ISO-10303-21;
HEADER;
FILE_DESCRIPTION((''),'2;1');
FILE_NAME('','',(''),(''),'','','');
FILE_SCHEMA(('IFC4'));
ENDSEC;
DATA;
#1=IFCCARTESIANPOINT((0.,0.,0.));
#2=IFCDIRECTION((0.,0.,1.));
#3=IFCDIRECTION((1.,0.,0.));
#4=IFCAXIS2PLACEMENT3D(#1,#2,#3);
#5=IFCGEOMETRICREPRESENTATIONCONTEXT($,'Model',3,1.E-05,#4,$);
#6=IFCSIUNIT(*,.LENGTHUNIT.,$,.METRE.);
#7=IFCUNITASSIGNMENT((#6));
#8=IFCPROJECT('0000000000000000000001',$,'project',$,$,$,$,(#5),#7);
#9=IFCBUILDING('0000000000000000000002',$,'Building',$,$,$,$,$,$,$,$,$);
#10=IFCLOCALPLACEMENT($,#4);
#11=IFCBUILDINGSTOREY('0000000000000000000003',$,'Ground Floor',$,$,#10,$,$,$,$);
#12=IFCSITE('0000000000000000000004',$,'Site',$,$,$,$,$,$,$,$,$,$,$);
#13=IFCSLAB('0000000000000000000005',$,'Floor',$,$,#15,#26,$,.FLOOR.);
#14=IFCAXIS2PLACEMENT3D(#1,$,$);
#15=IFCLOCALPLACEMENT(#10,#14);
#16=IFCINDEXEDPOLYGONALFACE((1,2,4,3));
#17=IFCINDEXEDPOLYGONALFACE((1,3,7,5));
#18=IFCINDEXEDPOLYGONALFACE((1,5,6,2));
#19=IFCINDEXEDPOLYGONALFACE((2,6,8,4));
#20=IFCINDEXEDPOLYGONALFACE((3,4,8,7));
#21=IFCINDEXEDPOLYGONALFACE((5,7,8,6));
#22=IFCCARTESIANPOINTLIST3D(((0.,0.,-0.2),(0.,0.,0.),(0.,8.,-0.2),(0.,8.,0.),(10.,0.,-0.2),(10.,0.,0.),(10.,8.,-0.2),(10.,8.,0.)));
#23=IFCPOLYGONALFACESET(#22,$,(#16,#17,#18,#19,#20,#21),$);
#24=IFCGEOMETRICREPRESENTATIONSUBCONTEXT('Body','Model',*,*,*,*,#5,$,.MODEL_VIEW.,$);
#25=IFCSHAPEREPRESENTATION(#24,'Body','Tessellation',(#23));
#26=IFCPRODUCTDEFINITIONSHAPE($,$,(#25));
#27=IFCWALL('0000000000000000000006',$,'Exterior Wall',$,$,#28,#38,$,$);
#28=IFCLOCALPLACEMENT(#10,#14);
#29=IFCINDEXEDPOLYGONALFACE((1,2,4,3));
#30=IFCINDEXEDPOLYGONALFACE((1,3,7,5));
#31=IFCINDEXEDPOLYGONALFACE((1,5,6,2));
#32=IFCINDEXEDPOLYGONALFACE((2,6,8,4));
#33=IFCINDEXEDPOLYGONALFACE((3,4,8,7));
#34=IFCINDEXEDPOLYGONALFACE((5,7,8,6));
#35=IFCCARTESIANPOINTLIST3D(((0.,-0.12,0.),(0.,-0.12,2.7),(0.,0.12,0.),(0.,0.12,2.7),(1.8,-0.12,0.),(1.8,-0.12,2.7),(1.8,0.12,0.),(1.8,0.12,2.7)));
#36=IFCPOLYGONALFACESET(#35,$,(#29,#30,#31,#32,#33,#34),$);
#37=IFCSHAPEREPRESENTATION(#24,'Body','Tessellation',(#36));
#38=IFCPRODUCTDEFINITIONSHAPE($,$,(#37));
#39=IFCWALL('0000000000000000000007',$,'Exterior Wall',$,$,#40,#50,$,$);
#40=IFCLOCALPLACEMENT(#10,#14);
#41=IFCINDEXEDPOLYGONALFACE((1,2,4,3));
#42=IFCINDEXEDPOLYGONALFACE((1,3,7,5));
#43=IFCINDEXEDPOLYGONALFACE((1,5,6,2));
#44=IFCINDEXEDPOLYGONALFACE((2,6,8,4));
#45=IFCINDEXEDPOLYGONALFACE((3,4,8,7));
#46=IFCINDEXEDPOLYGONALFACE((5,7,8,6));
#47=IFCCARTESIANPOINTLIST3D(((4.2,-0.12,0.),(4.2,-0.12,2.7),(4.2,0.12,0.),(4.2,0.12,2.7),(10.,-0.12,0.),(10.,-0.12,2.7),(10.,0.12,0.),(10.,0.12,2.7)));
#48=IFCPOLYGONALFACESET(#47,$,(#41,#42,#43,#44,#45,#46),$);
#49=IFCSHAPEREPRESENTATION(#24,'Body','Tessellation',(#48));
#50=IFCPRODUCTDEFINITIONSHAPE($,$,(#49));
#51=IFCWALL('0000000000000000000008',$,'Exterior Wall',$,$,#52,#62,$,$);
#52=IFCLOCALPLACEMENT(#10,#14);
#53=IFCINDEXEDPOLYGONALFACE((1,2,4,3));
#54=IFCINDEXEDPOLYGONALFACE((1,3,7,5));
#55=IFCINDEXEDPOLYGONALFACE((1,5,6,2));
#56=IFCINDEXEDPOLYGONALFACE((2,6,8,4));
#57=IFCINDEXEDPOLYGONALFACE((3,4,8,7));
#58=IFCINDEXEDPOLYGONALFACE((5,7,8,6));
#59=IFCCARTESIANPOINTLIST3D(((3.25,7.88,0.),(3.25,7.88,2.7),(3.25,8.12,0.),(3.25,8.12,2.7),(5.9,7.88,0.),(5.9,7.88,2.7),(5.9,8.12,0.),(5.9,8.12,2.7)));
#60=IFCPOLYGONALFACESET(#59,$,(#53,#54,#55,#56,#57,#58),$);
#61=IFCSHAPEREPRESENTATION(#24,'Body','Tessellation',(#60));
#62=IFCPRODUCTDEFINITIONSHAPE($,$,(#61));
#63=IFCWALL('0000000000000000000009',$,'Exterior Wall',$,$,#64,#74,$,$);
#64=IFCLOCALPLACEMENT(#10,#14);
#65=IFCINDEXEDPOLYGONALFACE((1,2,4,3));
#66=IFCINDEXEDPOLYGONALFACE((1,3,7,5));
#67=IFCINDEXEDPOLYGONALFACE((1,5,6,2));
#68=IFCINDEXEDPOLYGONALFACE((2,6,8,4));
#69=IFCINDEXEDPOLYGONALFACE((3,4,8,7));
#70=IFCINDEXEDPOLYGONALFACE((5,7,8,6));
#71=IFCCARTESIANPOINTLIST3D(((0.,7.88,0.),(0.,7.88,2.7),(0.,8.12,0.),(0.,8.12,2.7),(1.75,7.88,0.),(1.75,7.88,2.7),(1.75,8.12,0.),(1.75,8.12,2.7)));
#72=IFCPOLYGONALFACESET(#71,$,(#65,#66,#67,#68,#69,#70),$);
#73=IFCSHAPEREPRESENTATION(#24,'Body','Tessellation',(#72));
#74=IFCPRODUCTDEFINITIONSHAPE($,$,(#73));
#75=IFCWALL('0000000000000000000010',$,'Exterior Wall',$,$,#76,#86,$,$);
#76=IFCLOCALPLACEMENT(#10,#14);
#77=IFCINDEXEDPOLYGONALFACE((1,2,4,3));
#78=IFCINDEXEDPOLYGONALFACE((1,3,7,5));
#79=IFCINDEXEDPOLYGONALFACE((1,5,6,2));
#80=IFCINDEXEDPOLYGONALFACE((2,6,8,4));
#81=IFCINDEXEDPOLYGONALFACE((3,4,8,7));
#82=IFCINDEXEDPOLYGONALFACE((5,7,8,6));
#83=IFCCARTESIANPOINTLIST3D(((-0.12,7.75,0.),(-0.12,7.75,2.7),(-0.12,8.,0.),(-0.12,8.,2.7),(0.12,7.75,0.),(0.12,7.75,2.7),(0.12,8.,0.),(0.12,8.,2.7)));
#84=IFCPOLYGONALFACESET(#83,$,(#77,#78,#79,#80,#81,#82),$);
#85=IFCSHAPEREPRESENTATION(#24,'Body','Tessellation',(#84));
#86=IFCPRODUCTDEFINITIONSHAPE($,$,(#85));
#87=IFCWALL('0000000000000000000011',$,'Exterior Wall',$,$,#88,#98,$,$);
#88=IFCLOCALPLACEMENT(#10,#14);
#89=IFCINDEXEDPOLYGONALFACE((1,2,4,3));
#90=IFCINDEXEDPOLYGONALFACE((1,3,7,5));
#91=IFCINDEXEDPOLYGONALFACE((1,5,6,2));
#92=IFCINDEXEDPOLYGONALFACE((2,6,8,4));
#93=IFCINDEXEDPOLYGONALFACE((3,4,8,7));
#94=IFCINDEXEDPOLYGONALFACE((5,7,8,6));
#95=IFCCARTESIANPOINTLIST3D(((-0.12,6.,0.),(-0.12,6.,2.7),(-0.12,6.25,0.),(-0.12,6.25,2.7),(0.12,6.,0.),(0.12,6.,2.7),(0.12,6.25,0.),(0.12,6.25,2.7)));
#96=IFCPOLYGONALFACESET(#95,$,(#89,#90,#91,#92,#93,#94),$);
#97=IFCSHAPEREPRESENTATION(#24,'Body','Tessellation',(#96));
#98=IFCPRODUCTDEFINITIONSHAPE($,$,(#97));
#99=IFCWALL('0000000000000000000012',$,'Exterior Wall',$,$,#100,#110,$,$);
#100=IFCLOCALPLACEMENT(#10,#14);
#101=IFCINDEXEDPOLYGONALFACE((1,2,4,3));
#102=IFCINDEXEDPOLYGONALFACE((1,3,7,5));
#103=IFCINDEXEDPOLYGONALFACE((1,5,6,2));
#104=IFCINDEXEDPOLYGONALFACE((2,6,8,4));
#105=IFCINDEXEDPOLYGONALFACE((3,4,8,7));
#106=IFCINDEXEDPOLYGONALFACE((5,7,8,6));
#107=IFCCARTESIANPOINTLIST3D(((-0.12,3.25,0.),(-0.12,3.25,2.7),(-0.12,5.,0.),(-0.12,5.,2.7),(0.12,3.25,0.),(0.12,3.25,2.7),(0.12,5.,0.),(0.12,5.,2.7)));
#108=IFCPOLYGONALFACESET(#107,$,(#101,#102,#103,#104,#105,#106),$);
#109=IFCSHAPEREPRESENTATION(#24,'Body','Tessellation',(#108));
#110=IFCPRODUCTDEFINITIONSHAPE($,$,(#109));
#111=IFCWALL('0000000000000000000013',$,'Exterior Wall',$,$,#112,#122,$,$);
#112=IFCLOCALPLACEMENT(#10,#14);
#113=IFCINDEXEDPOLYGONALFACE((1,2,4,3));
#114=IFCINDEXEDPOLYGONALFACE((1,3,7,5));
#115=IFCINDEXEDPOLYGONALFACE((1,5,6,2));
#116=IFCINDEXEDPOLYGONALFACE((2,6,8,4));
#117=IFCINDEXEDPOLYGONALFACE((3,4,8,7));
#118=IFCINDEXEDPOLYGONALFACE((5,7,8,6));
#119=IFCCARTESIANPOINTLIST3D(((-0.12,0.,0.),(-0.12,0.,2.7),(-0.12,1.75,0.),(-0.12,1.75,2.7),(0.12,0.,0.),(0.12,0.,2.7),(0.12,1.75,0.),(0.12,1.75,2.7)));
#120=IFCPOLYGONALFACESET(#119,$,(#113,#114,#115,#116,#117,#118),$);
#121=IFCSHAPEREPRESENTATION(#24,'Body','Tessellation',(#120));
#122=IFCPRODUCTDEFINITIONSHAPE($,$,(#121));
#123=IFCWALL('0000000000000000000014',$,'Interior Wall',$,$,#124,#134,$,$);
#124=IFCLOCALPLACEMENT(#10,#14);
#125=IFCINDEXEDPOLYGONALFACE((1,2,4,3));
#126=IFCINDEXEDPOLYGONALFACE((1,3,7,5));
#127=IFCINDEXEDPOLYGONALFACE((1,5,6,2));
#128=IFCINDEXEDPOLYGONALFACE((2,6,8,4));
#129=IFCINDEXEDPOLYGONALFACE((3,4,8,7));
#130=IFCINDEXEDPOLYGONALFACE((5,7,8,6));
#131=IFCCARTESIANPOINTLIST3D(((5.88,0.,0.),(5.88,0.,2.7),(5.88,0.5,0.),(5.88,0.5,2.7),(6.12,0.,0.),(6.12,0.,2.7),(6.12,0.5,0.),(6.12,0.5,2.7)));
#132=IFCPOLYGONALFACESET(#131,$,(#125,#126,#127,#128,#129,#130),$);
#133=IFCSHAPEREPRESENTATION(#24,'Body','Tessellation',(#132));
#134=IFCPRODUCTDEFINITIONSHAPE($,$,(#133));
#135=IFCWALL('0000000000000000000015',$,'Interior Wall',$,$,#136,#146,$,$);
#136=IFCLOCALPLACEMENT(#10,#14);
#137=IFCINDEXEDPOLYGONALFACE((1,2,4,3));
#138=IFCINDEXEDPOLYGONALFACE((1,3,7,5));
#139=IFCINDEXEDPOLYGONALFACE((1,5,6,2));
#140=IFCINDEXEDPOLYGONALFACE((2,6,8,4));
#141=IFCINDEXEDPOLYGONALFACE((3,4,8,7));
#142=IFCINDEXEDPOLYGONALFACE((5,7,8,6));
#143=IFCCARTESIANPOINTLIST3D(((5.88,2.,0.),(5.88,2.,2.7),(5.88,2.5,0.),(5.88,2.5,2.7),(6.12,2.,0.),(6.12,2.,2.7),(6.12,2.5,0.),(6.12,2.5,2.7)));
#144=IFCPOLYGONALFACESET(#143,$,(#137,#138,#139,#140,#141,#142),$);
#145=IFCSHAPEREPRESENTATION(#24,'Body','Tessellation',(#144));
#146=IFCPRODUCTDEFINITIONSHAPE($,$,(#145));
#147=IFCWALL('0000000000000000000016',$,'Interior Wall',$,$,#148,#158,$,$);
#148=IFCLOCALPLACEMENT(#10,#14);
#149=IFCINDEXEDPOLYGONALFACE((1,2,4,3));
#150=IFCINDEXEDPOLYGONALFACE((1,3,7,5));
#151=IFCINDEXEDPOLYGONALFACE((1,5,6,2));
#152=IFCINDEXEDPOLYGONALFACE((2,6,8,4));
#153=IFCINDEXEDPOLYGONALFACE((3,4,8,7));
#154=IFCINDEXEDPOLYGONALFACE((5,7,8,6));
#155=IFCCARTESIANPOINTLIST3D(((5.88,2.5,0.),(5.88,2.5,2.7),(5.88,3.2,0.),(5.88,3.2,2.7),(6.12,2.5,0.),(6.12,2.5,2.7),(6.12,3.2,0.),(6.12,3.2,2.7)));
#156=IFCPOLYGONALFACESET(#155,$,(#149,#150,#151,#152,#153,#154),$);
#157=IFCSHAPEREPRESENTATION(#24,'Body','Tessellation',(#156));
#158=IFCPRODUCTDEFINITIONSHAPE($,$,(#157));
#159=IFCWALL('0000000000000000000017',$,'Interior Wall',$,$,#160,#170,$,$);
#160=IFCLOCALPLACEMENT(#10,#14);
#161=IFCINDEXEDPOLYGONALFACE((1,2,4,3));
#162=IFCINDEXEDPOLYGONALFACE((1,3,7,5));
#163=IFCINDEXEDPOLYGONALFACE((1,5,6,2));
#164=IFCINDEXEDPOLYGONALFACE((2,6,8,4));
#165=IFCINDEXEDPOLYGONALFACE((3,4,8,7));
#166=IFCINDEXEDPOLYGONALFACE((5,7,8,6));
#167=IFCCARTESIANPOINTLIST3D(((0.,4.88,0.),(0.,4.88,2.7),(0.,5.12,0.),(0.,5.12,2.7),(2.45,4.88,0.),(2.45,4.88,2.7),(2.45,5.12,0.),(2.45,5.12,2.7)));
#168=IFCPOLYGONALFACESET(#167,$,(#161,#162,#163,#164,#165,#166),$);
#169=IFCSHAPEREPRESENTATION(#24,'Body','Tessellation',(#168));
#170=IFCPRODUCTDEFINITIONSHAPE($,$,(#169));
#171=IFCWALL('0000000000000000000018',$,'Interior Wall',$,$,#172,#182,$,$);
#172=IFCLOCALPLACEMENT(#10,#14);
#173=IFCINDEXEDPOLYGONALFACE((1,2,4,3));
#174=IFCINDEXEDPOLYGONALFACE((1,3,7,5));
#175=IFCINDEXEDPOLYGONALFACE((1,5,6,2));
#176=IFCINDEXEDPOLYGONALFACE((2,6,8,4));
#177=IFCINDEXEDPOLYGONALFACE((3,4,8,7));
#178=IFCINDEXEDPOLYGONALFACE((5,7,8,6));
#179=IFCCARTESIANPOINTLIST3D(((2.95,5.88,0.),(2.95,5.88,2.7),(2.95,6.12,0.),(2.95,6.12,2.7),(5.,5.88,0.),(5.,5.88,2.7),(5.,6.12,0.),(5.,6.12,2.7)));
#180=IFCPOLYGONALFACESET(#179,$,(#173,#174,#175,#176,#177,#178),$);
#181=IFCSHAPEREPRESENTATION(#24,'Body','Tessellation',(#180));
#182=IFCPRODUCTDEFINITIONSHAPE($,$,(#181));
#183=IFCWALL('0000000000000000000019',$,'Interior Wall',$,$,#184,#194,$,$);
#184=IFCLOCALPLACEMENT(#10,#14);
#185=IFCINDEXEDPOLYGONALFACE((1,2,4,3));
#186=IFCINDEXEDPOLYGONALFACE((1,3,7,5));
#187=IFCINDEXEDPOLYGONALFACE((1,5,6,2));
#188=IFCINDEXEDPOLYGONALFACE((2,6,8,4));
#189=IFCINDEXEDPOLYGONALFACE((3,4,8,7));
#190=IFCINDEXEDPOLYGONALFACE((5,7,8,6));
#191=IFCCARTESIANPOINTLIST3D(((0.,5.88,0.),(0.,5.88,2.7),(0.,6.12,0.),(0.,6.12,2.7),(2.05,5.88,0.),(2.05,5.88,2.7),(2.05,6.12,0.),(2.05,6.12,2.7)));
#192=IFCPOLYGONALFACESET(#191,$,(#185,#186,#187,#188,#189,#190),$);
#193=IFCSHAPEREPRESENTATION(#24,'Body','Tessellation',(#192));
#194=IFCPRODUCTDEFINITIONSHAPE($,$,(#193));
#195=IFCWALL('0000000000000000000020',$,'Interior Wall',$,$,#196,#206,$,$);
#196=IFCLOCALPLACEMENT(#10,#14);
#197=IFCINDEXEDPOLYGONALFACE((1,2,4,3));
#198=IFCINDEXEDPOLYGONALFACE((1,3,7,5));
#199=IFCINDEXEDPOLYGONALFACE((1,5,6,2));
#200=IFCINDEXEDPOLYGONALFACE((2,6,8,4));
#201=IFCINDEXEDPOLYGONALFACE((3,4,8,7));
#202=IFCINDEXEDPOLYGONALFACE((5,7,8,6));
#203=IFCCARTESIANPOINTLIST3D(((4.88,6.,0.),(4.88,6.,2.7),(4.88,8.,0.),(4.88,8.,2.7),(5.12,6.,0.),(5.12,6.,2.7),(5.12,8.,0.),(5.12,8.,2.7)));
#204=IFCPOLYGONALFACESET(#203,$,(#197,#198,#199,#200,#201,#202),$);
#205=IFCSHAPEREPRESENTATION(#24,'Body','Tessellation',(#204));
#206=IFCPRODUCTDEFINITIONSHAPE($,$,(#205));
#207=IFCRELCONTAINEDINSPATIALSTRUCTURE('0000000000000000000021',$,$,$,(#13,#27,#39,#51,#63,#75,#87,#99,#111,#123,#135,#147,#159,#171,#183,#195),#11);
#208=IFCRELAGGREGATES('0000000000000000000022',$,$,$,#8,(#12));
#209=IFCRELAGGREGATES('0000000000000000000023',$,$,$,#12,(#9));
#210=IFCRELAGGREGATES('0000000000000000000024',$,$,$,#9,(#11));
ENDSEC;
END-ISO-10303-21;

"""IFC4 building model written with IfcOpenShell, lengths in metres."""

from ifc_helpers import new_model, si_unit, frame, origin_with_axes, place, context, subcontext, project, spatial, indexed_curve, outline, extrude, element, save


model = new_model("IFC4")

# Units and contexts
model_context = context("Model", 3, precision=1e-05, world=origin_with_axes())
body_context = subcontext(model_context, "Body", "Model", "MODEL_VIEW")
ifc_project = project(units=[si_unit("LENGTHUNIT", "METRE")], contexts=[model_context])

# Site, building, storey
site = spatial("IfcSite", under=ifc_project, Name="Site")
building = spatial("IfcBuilding", under=site, Name="Building")
storey_placement = place(None, origin_with_axes())
storey = spatial("IfcBuildingStorey", under=building, at=storey_placement, Name="Ground Floor")

# Slab
slab_placement = place(storey_placement, frame((0.0, 0.0, -0.2), z_axis=(0.0, 0.0, 1.0), x_axis=(1.0, 0.0, 0.0)))
element("IfcSlab", 1, at=slab_placement, inside=storey, Name="Floor", PredefinedType="FLOOR", context=body_context, shape_type="SweptSolid", body=[
    extrude(outline(indexed_curve([(0.0, 0.0), (10.0, 0.0), (10.0, 8.0), (0.0, 8.0)])), None, (0.0, 0.0, 1.0), 0.2),
])

# Walls
wall_1_placement = place(storey_placement, origin_with_axes())
element("IfcWall", 2, at=wall_1_placement, inside=storey, Name="Exterior Wall", context=body_context, shape_type="SweptSolid", body=[
    extrude(outline(indexed_curve([(0.0, 0.0), (0.0, 0.24), (1.8, 0.24), (1.8, 0.0), (0.0, 0.0)], self_intersect=False)), frame((0.0, -0.12, 0.0), z_axis=(0.0, 0.0, 1.0), x_axis=(1.0, 0.0, 0.0)), (0.0, 0.0, 1.0), 2.7),
])
wall_2_placement = place(storey_placement, frame((4.2, 0.0, 0.0), z_axis=(0.0, 0.0, 1.0), x_axis=(1.0, 0.0, 0.0)))
element("IfcWall", 3, at=wall_2_placement, inside=storey, Name="Exterior Wall", context=body_context, shape_type="SweptSolid", body=[
    extrude(outline(indexed_curve([(0.0, 0.0), (0.0, 0.24), (5.8, 0.24), (5.8, 0.0), (0.0, 0.0)], self_intersect=False)), frame((0.0, -0.12, 0.0), z_axis=(0.0, 0.0, 1.0), x_axis=(1.0, 0.0, 0.0)), (0.0, 0.0, 1.0), 2.7),
])
wall_3_placement = place(storey_placement, frame((5.9, 8.0, 0.0), z_axis=(0.0, 0.0, 1.0), x_axis=(-1.0, 0.0, 0.0)))
element("IfcWall", 4, at=wall_3_placement, inside=storey, Name="Exterior Wall", context=body_context, shape_type="SweptSolid", body=[
    extrude(outline(indexed_curve([(0.0, 0.0), (0.0, 0.24), (2.65, 0.24), (2.65, 0.0), (0.0, 0.0)], self_intersect=False)), frame((0.0, -0.12, 0.0), z_axis=(0.0, 0.0, 1.0), x_axis=(1.0, 0.0, 0.0)), (0.0, 0.0, 1.0), 2.7),
])
wall_4_placement = place(storey_placement, frame((1.75, 8.0, 0.0), z_axis=(0.0, 0.0, 1.0), x_axis=(-1.0, 0.0, 0.0)))
element("IfcWall", 5, at=wall_4_placement, inside=storey, Name="Exterior Wall", context=body_context, shape_type="SweptSolid", body=[
    extrude(outline(indexed_curve([(0.0, 0.0), (0.0, 0.24), (1.75, 0.24), (1.75, 0.0), (0.0, 0.0)], self_intersect=False)), frame((0.0, -0.12, 0.0), z_axis=(0.0, 0.0, 1.0), x_axis=(1.0, 0.0, 0.0)), (0.0, 0.0, 1.0), 2.7),
])
for number, where, z_axis, x_axis, name in (
    (6, (0.0, 8.0, 0.0), (0.0, 0.0, 1.0), (0.0, -1.0, 0.0), "Exterior Wall"),
    (7, (0.0, 6.25, 0.0), (0.0, 0.0, 1.0), (0.0, -1.0, 0.0), "Exterior Wall"),
):
    element("IfcWall", number, at=place(storey_placement, frame(where, z_axis=z_axis, x_axis=x_axis)), inside=storey, Name=name, context=body_context, shape_type="SweptSolid", body=[
        extrude(outline(indexed_curve([(0.0, 0.0), (0.0, 0.24), (0.25, 0.24), (0.25, 0.0), (0.0, 0.0)], self_intersect=False)), frame((0.0, -0.12, 0.0), z_axis=(0.0, 0.0, 1.0), x_axis=(1.0, 0.0, 0.0)), (0.0, 0.0, 1.0), 2.7),
    ])
for number, where, z_axis, x_axis, name in (
    (8, (0.0, 5.0, 0.0), (0.0, 0.0, 1.0), (0.0, -1.0, 0.0), "Exterior Wall"),
    (9, (0.0, 1.75, 0.0), (0.0, 0.0, 1.0), (0.0, -1.0, 0.0), "Exterior Wall"),
):
    element("IfcWall", number, at=place(storey_placement, frame(where, z_axis=z_axis, x_axis=x_axis)), inside=storey, Name=name, context=body_context, shape_type="SweptSolid", body=[
        extrude(outline(indexed_curve([(0.0, 0.0), (0.0, 0.24), (1.75, 0.24), (1.75, 0.0), (0.0, 0.0)], self_intersect=False)), frame((0.0, -0.12, 0.0), z_axis=(0.0, 0.0, 1.0), x_axis=(1.0, 0.0, 0.0)), (0.0, 0.0, 1.0), 2.7),
    ])
for number, where, z_axis, x_axis, name in (
    (10, (6.0, 0.0, 0.0), (0.0, 0.0, 1.0), (0.0, 1.0, 0.0), "Interior Wall"),
    (11, (6.0, 2.0, 0.0), (0.0, 0.0, 1.0), (0.0, 1.0, 0.0), "Interior Wall"),
):
    element("IfcWall", number, at=place(storey_placement, frame(where, z_axis=z_axis, x_axis=x_axis)), inside=storey, Name=name, context=body_context, shape_type="SweptSolid", body=[
        extrude(outline(indexed_curve([(0.0, 0.0), (0.0, 0.24), (0.5, 0.24), (0.5, 0.0), (0.0, 0.0)], self_intersect=False)), frame((0.0, -0.12, 0.0), z_axis=(0.0, 0.0, 1.0), x_axis=(1.0, 0.0, 0.0)), (0.0, 0.0, 1.0), 2.7),
    ])
wall_5_placement = place(storey_placement, frame((6.0, 2.5, 0.0), z_axis=(0.0, 0.0, 1.0), x_axis=(0.0, 1.0, 0.0)))
element("IfcWall", 12, at=wall_5_placement, inside=storey, Name="Interior Wall", context=body_context, shape_type="SweptSolid", body=[
    extrude(outline(indexed_curve([(0.0, 0.0), (0.0, 0.24), (0.7, 0.24), (0.7, 0.0), (0.0, 0.0)], self_intersect=False)), frame((0.0, -0.12, 0.0), z_axis=(0.0, 0.0, 1.0), x_axis=(1.0, 0.0, 0.0)), (0.0, 0.0, 1.0), 2.7),
])
wall_6_placement = place(storey_placement, frame((2.45, 5.0, 0.0), z_axis=(0.0, 0.0, 1.0), x_axis=(-1.0, 0.0, 0.0)))
element("IfcWall", 13, at=wall_6_placement, inside=storey, Name="Interior Wall", context=body_context, shape_type="SweptSolid", body=[
    extrude(outline(indexed_curve([(0.0, 0.0), (0.0, 0.24), (2.45, 0.24), (2.45, 0.0), (0.0, 0.0)], self_intersect=False)), frame((0.0, -0.12, 0.0), z_axis=(0.0, 0.0, 1.0), x_axis=(1.0, 0.0, 0.0)), (0.0, 0.0, 1.0), 2.7),
])
for number, where, z_axis, x_axis, name in (
    (14, (5.0, 6.0, 0.0), (0.0, 0.0, 1.0), (-1.0, 0.0, 0.0), "Interior Wall"),
    (15, (2.05, 6.0, 0.0), (0.0, 0.0, 1.0), (-1.0, 0.0, 0.0), "Interior Wall"),
):
    element("IfcWall", number, at=place(storey_placement, frame(where, z_axis=z_axis, x_axis=x_axis)), inside=storey, Name=name, context=body_context, shape_type="SweptSolid", body=[
        extrude(outline(indexed_curve([(0.0, 0.0), (0.0, 0.24), (2.05, 0.24), (2.05, 0.0), (0.0, 0.0)], self_intersect=False)), frame((0.0, -0.12, 0.0), z_axis=(0.0, 0.0, 1.0), x_axis=(1.0, 0.0, 0.0)), (0.0, 0.0, 1.0), 2.7),
    ])
wall_7_placement = place(storey_placement, frame((5.0, 6.0, 0.0), z_axis=(0.0, 0.0, 1.0), x_axis=(0.0, 1.0, 0.0)))
element("IfcWall", 16, at=wall_7_placement, inside=storey, Name="Interior Wall", context=body_context, shape_type="SweptSolid", body=[
    extrude(outline(indexed_curve([(0.0, 0.0), (0.0, 0.24), (2.0, 0.24), (2.0, 0.0), (0.0, 0.0)], self_intersect=False)), frame((0.0, -0.12, 0.0), z_axis=(0.0, 0.0, 1.0), x_axis=(1.0, 0.0, 0.0)), (0.0, 0.0, 1.0), 2.7),
])

save(model, "model.ifc")
